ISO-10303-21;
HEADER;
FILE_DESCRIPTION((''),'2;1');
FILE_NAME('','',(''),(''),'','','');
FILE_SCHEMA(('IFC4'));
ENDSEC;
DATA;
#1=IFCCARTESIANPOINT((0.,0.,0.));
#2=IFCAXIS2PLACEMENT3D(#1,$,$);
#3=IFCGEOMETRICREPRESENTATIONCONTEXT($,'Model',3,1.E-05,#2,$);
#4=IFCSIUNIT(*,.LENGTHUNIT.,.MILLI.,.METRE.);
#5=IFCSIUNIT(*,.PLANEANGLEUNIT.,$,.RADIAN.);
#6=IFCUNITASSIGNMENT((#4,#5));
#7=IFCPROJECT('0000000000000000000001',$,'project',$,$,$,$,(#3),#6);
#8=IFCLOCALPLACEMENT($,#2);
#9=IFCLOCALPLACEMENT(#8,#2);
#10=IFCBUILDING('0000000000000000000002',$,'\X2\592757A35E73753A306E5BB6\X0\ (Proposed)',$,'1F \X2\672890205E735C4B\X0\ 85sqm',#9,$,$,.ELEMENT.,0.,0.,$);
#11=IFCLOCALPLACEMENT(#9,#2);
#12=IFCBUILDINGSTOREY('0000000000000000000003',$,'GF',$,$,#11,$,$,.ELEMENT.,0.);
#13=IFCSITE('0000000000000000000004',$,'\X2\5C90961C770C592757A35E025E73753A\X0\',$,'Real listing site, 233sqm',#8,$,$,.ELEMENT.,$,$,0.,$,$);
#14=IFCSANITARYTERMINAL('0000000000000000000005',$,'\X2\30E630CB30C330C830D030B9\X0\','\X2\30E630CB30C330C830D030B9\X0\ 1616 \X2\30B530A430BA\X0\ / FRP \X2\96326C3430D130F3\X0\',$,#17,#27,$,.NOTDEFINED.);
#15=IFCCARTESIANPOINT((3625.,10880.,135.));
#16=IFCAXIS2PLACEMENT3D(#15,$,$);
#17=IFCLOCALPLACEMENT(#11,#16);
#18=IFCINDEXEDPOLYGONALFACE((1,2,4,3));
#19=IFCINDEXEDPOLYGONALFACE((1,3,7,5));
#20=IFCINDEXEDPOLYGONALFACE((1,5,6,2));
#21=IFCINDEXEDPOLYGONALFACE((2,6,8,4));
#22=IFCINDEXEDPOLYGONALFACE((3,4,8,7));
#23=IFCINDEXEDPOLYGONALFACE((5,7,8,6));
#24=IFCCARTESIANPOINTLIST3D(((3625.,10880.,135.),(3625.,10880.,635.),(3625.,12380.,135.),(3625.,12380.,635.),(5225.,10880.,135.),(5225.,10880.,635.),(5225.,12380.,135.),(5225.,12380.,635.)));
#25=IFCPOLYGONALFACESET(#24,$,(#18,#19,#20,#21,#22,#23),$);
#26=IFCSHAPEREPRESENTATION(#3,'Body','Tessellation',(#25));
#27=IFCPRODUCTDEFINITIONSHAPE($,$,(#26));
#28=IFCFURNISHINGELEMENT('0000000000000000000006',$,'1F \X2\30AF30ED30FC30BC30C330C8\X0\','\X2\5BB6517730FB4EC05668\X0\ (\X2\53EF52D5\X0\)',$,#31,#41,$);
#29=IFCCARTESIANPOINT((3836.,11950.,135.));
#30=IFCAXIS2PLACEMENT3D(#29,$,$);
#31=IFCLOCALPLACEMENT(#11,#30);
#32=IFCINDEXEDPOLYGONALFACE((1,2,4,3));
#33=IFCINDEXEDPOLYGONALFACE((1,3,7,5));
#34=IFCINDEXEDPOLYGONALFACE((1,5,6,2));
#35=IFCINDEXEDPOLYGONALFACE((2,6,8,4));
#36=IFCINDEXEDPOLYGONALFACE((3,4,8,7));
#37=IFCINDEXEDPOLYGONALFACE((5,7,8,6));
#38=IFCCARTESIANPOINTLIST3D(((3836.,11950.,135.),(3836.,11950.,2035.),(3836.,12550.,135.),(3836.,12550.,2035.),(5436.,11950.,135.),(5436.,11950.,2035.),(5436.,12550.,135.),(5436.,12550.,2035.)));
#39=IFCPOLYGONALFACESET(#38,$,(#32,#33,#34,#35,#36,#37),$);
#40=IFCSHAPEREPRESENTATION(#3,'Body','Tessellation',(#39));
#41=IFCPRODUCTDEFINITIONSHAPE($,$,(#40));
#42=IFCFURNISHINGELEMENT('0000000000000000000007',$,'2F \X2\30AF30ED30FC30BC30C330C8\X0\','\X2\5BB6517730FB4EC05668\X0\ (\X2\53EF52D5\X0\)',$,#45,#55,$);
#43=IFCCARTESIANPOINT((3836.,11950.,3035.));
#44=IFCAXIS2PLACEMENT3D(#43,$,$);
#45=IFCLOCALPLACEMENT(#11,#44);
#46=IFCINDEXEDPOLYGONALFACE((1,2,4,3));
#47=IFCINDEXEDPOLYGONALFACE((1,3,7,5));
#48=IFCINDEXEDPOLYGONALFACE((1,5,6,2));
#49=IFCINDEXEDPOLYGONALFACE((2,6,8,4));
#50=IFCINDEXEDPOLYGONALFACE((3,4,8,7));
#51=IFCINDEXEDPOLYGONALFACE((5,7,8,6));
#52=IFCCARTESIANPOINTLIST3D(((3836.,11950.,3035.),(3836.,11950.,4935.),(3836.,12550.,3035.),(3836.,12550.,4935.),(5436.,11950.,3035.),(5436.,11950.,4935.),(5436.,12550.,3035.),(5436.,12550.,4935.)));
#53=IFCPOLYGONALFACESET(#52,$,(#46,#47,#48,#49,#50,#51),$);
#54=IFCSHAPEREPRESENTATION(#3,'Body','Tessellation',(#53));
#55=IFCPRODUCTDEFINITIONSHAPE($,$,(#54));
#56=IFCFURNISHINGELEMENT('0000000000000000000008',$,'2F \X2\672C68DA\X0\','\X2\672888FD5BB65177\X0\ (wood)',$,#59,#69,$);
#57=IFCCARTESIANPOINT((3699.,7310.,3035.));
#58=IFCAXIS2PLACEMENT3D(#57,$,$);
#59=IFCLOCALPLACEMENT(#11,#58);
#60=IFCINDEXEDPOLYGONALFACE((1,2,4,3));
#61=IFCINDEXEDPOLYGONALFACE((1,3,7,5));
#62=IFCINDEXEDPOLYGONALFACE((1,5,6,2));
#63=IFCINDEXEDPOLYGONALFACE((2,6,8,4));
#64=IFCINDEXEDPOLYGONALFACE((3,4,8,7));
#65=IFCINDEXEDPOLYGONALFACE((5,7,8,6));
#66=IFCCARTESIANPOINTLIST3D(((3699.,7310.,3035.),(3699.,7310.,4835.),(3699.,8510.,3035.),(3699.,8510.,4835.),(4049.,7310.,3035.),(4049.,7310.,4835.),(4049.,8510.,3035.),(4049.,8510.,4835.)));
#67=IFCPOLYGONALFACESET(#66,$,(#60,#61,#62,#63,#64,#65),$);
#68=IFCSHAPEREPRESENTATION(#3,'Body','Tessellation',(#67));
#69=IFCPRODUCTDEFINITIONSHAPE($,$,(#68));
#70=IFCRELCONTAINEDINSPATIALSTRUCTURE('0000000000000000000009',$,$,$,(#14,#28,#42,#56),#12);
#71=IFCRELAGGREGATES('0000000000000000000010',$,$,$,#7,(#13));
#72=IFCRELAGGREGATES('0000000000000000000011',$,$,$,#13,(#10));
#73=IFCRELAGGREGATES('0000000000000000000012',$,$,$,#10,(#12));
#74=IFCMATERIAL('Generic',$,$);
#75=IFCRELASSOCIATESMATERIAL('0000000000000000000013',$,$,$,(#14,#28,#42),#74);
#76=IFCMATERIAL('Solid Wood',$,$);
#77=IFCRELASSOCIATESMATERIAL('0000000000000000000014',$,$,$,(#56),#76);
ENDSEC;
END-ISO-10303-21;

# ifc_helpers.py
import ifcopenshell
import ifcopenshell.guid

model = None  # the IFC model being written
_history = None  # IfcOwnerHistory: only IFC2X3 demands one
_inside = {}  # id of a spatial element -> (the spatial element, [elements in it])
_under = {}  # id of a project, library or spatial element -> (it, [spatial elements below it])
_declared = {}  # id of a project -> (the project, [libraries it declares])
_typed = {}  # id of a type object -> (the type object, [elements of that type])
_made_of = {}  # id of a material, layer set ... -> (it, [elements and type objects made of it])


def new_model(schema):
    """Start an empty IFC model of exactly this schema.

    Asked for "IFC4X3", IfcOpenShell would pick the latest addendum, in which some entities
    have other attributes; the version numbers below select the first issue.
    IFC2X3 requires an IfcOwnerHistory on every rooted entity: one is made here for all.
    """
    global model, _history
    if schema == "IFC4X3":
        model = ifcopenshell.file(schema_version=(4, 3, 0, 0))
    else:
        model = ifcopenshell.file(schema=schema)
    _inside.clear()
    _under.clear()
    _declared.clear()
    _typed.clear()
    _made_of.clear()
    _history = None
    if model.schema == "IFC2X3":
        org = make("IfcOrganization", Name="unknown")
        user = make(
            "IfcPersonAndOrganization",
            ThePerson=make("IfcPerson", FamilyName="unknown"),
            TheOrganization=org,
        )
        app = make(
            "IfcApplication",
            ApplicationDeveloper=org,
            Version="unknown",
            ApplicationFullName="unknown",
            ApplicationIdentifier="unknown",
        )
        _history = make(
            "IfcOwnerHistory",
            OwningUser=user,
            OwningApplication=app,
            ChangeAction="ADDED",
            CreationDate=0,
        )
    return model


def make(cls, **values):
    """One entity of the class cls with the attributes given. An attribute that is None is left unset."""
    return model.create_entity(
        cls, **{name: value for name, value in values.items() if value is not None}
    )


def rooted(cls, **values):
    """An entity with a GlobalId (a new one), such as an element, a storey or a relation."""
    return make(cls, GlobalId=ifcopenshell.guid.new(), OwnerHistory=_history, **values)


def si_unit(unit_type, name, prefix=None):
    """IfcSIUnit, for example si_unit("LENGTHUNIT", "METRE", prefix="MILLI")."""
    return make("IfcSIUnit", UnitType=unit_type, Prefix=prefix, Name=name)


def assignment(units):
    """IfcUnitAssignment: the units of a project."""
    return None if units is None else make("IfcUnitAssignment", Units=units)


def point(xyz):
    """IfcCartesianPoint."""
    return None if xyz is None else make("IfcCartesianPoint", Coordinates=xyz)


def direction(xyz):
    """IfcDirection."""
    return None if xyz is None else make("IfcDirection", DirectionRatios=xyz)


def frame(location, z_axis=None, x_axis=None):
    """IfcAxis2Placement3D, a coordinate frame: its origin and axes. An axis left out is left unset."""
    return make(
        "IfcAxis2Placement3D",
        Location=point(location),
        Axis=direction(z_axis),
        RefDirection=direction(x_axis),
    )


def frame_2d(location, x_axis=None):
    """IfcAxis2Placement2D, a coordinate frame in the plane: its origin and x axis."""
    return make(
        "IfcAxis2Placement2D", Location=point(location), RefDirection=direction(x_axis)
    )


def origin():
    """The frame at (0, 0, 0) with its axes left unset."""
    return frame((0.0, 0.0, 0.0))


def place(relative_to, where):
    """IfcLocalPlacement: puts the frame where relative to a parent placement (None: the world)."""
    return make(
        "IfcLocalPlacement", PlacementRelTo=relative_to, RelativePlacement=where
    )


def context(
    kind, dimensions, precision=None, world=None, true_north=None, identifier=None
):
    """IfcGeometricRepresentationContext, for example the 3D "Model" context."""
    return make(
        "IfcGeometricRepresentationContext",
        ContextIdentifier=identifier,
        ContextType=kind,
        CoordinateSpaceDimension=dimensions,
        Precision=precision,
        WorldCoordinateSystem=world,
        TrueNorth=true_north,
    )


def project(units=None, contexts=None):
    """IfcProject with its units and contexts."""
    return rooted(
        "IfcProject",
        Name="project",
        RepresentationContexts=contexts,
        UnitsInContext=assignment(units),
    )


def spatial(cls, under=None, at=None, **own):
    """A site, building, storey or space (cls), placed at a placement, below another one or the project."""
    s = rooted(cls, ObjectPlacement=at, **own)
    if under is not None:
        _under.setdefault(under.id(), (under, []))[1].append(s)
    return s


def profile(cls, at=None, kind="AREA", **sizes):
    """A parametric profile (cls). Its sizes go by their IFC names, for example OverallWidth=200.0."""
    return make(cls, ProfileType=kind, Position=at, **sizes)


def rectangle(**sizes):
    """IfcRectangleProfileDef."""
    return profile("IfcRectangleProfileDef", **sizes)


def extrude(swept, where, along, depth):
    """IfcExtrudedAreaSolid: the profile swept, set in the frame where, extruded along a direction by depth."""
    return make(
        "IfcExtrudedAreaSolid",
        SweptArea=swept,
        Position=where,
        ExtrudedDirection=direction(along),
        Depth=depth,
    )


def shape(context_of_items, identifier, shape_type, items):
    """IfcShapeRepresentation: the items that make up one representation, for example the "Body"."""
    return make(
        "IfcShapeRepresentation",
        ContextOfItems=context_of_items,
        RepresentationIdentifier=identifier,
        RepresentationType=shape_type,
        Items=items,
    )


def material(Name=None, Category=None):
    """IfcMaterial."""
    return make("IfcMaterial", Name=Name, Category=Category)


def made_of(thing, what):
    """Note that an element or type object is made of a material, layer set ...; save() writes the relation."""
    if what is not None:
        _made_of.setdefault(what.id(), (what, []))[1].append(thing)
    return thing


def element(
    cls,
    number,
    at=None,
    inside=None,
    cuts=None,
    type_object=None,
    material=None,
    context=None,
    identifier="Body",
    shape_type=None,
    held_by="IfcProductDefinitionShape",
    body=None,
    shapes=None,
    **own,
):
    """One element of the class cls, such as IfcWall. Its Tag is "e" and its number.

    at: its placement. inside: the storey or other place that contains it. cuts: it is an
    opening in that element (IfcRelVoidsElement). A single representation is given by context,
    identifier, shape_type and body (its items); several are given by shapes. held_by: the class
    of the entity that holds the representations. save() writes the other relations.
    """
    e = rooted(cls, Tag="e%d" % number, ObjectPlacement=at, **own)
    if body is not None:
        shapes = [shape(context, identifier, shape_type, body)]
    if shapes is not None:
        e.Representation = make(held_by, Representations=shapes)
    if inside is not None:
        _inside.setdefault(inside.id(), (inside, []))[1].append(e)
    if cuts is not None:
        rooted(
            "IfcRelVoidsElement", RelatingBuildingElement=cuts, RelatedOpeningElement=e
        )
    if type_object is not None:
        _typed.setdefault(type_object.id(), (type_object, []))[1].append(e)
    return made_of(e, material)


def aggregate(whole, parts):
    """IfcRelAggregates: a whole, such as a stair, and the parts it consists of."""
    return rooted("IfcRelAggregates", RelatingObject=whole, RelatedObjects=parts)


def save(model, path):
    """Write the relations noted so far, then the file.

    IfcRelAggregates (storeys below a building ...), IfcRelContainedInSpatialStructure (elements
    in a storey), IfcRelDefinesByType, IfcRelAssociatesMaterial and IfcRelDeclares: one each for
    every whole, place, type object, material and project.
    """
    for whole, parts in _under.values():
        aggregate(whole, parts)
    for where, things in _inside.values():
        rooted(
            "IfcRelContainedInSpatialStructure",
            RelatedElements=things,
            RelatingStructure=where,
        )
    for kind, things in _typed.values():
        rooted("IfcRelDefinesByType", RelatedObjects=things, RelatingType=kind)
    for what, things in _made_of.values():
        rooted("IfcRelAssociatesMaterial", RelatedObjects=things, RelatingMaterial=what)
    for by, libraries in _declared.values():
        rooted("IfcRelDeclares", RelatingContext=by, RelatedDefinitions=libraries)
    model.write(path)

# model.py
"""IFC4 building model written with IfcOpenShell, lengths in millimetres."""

from ifc_helpers import new_model, si_unit, frame, frame_2d, origin, place, context, project, spatial, rectangle, extrude, material, element, save


model = new_model("IFC4")

# Units and contexts
model_context = context("Model", 3, precision=1e-05, world=origin())
ifc_project = project(units=[si_unit("LENGTHUNIT", "METRE", prefix="MILLI"), si_unit("PLANEANGLEUNIT", "RADIAN")], contexts=[model_context])

# Site, building, storey
site_placement = place(None, origin())
site = spatial("IfcSite", under=ifc_project, at=site_placement, Name="岐阜県大垣市平町", ObjectType="Real listing site, 233sqm", CompositionType="ELEMENT", RefElevation=0.0)
building_placement = place(site_placement, origin())
building = spatial("IfcBuilding", under=site, at=building_placement, Name="大垣平町の家 (Proposed)", ObjectType="1F 木造平屋 85sqm", CompositionType="ELEMENT", ElevationOfRefHeight=0.0, ElevationOfTerrain=0.0)
storey_placement = place(building_placement, origin())
storey = spatial("IfcBuildingStorey", under=building, at=storey_placement, Name="GF", CompositionType="ELEMENT", Elevation=0.0)

# Shared definitions
ifc_material_1 = material(Name="Solid Wood")

# Shared definitions
ifc_material_2 = material(Name="Generic")

# Sanitary terminal
sanitary_terminal_placement = place(storey_placement, frame((3625.0, 10880.0, 135.0)))
element("IfcSanitaryTerminal", 1, at=sanitary_terminal_placement, inside=storey, material=ifc_material_2, Name="ユニットバス", Description="ユニットバス 1616 サイズ / FRP 防水パン", PredefinedType="NOTDEFINED", context=model_context, shape_type="SweptSolid", body=[
    extrude(rectangle(XDim=1600.0, YDim=1500.0, at=frame_2d((800.0, 750.0))), frame((3625.0, 10880.0, 135.0)), (0.0, 0.0, 1.0), 500.0),
])

# Furnishing elements
furnishing_1_placement = place(storey_placement, frame((3836.0, 11950.0, 135.0)))
element("IfcFurnishingElement", 2, at=furnishing_1_placement, inside=storey, material=ifc_material_2, Name="1F クローゼット", Description="家具・什器 (可動)", context=model_context, shape_type="SweptSolid", body=[
    extrude(rectangle(XDim=1600.0, YDim=600.0, at=frame_2d((800.0, 300.0))), frame((3836.0, 11950.0, 135.0)), (0.0, 0.0, 1.0), 1900.0),
])
furnishing_2_placement = place(storey_placement, frame((3836.0, 11950.0, 3035.0)))
element("IfcFurnishingElement", 3, at=furnishing_2_placement, inside=storey, material=ifc_material_2, Name="2F クローゼット", Description="家具・什器 (可動)", context=model_context, shape_type="SweptSolid", body=[
    extrude(rectangle(XDim=1600.0, YDim=600.0, at=frame_2d((800.0, 300.0))), frame((3836.0, 11950.0, 3035.0)), (0.0, 0.0, 1.0), 1900.0),
])
furnishing_3_placement = place(storey_placement, frame((3699.0, 7310.0, 3035.0)))
element("IfcFurnishingElement", 4, at=furnishing_3_placement, inside=storey, material=ifc_material_1, Name="2F 本棚", Description="木製家具 (wood)", context=model_context, shape_type="SweptSolid", body=[
    extrude(rectangle(XDim=350.0, YDim=1200.0, at=frame_2d((175.0, 600.0))), frame((3699.0, 7310.0, 3035.0)), (0.0, 0.0, 1.0), 1800.0),
])

save(model, "model.ifc")
